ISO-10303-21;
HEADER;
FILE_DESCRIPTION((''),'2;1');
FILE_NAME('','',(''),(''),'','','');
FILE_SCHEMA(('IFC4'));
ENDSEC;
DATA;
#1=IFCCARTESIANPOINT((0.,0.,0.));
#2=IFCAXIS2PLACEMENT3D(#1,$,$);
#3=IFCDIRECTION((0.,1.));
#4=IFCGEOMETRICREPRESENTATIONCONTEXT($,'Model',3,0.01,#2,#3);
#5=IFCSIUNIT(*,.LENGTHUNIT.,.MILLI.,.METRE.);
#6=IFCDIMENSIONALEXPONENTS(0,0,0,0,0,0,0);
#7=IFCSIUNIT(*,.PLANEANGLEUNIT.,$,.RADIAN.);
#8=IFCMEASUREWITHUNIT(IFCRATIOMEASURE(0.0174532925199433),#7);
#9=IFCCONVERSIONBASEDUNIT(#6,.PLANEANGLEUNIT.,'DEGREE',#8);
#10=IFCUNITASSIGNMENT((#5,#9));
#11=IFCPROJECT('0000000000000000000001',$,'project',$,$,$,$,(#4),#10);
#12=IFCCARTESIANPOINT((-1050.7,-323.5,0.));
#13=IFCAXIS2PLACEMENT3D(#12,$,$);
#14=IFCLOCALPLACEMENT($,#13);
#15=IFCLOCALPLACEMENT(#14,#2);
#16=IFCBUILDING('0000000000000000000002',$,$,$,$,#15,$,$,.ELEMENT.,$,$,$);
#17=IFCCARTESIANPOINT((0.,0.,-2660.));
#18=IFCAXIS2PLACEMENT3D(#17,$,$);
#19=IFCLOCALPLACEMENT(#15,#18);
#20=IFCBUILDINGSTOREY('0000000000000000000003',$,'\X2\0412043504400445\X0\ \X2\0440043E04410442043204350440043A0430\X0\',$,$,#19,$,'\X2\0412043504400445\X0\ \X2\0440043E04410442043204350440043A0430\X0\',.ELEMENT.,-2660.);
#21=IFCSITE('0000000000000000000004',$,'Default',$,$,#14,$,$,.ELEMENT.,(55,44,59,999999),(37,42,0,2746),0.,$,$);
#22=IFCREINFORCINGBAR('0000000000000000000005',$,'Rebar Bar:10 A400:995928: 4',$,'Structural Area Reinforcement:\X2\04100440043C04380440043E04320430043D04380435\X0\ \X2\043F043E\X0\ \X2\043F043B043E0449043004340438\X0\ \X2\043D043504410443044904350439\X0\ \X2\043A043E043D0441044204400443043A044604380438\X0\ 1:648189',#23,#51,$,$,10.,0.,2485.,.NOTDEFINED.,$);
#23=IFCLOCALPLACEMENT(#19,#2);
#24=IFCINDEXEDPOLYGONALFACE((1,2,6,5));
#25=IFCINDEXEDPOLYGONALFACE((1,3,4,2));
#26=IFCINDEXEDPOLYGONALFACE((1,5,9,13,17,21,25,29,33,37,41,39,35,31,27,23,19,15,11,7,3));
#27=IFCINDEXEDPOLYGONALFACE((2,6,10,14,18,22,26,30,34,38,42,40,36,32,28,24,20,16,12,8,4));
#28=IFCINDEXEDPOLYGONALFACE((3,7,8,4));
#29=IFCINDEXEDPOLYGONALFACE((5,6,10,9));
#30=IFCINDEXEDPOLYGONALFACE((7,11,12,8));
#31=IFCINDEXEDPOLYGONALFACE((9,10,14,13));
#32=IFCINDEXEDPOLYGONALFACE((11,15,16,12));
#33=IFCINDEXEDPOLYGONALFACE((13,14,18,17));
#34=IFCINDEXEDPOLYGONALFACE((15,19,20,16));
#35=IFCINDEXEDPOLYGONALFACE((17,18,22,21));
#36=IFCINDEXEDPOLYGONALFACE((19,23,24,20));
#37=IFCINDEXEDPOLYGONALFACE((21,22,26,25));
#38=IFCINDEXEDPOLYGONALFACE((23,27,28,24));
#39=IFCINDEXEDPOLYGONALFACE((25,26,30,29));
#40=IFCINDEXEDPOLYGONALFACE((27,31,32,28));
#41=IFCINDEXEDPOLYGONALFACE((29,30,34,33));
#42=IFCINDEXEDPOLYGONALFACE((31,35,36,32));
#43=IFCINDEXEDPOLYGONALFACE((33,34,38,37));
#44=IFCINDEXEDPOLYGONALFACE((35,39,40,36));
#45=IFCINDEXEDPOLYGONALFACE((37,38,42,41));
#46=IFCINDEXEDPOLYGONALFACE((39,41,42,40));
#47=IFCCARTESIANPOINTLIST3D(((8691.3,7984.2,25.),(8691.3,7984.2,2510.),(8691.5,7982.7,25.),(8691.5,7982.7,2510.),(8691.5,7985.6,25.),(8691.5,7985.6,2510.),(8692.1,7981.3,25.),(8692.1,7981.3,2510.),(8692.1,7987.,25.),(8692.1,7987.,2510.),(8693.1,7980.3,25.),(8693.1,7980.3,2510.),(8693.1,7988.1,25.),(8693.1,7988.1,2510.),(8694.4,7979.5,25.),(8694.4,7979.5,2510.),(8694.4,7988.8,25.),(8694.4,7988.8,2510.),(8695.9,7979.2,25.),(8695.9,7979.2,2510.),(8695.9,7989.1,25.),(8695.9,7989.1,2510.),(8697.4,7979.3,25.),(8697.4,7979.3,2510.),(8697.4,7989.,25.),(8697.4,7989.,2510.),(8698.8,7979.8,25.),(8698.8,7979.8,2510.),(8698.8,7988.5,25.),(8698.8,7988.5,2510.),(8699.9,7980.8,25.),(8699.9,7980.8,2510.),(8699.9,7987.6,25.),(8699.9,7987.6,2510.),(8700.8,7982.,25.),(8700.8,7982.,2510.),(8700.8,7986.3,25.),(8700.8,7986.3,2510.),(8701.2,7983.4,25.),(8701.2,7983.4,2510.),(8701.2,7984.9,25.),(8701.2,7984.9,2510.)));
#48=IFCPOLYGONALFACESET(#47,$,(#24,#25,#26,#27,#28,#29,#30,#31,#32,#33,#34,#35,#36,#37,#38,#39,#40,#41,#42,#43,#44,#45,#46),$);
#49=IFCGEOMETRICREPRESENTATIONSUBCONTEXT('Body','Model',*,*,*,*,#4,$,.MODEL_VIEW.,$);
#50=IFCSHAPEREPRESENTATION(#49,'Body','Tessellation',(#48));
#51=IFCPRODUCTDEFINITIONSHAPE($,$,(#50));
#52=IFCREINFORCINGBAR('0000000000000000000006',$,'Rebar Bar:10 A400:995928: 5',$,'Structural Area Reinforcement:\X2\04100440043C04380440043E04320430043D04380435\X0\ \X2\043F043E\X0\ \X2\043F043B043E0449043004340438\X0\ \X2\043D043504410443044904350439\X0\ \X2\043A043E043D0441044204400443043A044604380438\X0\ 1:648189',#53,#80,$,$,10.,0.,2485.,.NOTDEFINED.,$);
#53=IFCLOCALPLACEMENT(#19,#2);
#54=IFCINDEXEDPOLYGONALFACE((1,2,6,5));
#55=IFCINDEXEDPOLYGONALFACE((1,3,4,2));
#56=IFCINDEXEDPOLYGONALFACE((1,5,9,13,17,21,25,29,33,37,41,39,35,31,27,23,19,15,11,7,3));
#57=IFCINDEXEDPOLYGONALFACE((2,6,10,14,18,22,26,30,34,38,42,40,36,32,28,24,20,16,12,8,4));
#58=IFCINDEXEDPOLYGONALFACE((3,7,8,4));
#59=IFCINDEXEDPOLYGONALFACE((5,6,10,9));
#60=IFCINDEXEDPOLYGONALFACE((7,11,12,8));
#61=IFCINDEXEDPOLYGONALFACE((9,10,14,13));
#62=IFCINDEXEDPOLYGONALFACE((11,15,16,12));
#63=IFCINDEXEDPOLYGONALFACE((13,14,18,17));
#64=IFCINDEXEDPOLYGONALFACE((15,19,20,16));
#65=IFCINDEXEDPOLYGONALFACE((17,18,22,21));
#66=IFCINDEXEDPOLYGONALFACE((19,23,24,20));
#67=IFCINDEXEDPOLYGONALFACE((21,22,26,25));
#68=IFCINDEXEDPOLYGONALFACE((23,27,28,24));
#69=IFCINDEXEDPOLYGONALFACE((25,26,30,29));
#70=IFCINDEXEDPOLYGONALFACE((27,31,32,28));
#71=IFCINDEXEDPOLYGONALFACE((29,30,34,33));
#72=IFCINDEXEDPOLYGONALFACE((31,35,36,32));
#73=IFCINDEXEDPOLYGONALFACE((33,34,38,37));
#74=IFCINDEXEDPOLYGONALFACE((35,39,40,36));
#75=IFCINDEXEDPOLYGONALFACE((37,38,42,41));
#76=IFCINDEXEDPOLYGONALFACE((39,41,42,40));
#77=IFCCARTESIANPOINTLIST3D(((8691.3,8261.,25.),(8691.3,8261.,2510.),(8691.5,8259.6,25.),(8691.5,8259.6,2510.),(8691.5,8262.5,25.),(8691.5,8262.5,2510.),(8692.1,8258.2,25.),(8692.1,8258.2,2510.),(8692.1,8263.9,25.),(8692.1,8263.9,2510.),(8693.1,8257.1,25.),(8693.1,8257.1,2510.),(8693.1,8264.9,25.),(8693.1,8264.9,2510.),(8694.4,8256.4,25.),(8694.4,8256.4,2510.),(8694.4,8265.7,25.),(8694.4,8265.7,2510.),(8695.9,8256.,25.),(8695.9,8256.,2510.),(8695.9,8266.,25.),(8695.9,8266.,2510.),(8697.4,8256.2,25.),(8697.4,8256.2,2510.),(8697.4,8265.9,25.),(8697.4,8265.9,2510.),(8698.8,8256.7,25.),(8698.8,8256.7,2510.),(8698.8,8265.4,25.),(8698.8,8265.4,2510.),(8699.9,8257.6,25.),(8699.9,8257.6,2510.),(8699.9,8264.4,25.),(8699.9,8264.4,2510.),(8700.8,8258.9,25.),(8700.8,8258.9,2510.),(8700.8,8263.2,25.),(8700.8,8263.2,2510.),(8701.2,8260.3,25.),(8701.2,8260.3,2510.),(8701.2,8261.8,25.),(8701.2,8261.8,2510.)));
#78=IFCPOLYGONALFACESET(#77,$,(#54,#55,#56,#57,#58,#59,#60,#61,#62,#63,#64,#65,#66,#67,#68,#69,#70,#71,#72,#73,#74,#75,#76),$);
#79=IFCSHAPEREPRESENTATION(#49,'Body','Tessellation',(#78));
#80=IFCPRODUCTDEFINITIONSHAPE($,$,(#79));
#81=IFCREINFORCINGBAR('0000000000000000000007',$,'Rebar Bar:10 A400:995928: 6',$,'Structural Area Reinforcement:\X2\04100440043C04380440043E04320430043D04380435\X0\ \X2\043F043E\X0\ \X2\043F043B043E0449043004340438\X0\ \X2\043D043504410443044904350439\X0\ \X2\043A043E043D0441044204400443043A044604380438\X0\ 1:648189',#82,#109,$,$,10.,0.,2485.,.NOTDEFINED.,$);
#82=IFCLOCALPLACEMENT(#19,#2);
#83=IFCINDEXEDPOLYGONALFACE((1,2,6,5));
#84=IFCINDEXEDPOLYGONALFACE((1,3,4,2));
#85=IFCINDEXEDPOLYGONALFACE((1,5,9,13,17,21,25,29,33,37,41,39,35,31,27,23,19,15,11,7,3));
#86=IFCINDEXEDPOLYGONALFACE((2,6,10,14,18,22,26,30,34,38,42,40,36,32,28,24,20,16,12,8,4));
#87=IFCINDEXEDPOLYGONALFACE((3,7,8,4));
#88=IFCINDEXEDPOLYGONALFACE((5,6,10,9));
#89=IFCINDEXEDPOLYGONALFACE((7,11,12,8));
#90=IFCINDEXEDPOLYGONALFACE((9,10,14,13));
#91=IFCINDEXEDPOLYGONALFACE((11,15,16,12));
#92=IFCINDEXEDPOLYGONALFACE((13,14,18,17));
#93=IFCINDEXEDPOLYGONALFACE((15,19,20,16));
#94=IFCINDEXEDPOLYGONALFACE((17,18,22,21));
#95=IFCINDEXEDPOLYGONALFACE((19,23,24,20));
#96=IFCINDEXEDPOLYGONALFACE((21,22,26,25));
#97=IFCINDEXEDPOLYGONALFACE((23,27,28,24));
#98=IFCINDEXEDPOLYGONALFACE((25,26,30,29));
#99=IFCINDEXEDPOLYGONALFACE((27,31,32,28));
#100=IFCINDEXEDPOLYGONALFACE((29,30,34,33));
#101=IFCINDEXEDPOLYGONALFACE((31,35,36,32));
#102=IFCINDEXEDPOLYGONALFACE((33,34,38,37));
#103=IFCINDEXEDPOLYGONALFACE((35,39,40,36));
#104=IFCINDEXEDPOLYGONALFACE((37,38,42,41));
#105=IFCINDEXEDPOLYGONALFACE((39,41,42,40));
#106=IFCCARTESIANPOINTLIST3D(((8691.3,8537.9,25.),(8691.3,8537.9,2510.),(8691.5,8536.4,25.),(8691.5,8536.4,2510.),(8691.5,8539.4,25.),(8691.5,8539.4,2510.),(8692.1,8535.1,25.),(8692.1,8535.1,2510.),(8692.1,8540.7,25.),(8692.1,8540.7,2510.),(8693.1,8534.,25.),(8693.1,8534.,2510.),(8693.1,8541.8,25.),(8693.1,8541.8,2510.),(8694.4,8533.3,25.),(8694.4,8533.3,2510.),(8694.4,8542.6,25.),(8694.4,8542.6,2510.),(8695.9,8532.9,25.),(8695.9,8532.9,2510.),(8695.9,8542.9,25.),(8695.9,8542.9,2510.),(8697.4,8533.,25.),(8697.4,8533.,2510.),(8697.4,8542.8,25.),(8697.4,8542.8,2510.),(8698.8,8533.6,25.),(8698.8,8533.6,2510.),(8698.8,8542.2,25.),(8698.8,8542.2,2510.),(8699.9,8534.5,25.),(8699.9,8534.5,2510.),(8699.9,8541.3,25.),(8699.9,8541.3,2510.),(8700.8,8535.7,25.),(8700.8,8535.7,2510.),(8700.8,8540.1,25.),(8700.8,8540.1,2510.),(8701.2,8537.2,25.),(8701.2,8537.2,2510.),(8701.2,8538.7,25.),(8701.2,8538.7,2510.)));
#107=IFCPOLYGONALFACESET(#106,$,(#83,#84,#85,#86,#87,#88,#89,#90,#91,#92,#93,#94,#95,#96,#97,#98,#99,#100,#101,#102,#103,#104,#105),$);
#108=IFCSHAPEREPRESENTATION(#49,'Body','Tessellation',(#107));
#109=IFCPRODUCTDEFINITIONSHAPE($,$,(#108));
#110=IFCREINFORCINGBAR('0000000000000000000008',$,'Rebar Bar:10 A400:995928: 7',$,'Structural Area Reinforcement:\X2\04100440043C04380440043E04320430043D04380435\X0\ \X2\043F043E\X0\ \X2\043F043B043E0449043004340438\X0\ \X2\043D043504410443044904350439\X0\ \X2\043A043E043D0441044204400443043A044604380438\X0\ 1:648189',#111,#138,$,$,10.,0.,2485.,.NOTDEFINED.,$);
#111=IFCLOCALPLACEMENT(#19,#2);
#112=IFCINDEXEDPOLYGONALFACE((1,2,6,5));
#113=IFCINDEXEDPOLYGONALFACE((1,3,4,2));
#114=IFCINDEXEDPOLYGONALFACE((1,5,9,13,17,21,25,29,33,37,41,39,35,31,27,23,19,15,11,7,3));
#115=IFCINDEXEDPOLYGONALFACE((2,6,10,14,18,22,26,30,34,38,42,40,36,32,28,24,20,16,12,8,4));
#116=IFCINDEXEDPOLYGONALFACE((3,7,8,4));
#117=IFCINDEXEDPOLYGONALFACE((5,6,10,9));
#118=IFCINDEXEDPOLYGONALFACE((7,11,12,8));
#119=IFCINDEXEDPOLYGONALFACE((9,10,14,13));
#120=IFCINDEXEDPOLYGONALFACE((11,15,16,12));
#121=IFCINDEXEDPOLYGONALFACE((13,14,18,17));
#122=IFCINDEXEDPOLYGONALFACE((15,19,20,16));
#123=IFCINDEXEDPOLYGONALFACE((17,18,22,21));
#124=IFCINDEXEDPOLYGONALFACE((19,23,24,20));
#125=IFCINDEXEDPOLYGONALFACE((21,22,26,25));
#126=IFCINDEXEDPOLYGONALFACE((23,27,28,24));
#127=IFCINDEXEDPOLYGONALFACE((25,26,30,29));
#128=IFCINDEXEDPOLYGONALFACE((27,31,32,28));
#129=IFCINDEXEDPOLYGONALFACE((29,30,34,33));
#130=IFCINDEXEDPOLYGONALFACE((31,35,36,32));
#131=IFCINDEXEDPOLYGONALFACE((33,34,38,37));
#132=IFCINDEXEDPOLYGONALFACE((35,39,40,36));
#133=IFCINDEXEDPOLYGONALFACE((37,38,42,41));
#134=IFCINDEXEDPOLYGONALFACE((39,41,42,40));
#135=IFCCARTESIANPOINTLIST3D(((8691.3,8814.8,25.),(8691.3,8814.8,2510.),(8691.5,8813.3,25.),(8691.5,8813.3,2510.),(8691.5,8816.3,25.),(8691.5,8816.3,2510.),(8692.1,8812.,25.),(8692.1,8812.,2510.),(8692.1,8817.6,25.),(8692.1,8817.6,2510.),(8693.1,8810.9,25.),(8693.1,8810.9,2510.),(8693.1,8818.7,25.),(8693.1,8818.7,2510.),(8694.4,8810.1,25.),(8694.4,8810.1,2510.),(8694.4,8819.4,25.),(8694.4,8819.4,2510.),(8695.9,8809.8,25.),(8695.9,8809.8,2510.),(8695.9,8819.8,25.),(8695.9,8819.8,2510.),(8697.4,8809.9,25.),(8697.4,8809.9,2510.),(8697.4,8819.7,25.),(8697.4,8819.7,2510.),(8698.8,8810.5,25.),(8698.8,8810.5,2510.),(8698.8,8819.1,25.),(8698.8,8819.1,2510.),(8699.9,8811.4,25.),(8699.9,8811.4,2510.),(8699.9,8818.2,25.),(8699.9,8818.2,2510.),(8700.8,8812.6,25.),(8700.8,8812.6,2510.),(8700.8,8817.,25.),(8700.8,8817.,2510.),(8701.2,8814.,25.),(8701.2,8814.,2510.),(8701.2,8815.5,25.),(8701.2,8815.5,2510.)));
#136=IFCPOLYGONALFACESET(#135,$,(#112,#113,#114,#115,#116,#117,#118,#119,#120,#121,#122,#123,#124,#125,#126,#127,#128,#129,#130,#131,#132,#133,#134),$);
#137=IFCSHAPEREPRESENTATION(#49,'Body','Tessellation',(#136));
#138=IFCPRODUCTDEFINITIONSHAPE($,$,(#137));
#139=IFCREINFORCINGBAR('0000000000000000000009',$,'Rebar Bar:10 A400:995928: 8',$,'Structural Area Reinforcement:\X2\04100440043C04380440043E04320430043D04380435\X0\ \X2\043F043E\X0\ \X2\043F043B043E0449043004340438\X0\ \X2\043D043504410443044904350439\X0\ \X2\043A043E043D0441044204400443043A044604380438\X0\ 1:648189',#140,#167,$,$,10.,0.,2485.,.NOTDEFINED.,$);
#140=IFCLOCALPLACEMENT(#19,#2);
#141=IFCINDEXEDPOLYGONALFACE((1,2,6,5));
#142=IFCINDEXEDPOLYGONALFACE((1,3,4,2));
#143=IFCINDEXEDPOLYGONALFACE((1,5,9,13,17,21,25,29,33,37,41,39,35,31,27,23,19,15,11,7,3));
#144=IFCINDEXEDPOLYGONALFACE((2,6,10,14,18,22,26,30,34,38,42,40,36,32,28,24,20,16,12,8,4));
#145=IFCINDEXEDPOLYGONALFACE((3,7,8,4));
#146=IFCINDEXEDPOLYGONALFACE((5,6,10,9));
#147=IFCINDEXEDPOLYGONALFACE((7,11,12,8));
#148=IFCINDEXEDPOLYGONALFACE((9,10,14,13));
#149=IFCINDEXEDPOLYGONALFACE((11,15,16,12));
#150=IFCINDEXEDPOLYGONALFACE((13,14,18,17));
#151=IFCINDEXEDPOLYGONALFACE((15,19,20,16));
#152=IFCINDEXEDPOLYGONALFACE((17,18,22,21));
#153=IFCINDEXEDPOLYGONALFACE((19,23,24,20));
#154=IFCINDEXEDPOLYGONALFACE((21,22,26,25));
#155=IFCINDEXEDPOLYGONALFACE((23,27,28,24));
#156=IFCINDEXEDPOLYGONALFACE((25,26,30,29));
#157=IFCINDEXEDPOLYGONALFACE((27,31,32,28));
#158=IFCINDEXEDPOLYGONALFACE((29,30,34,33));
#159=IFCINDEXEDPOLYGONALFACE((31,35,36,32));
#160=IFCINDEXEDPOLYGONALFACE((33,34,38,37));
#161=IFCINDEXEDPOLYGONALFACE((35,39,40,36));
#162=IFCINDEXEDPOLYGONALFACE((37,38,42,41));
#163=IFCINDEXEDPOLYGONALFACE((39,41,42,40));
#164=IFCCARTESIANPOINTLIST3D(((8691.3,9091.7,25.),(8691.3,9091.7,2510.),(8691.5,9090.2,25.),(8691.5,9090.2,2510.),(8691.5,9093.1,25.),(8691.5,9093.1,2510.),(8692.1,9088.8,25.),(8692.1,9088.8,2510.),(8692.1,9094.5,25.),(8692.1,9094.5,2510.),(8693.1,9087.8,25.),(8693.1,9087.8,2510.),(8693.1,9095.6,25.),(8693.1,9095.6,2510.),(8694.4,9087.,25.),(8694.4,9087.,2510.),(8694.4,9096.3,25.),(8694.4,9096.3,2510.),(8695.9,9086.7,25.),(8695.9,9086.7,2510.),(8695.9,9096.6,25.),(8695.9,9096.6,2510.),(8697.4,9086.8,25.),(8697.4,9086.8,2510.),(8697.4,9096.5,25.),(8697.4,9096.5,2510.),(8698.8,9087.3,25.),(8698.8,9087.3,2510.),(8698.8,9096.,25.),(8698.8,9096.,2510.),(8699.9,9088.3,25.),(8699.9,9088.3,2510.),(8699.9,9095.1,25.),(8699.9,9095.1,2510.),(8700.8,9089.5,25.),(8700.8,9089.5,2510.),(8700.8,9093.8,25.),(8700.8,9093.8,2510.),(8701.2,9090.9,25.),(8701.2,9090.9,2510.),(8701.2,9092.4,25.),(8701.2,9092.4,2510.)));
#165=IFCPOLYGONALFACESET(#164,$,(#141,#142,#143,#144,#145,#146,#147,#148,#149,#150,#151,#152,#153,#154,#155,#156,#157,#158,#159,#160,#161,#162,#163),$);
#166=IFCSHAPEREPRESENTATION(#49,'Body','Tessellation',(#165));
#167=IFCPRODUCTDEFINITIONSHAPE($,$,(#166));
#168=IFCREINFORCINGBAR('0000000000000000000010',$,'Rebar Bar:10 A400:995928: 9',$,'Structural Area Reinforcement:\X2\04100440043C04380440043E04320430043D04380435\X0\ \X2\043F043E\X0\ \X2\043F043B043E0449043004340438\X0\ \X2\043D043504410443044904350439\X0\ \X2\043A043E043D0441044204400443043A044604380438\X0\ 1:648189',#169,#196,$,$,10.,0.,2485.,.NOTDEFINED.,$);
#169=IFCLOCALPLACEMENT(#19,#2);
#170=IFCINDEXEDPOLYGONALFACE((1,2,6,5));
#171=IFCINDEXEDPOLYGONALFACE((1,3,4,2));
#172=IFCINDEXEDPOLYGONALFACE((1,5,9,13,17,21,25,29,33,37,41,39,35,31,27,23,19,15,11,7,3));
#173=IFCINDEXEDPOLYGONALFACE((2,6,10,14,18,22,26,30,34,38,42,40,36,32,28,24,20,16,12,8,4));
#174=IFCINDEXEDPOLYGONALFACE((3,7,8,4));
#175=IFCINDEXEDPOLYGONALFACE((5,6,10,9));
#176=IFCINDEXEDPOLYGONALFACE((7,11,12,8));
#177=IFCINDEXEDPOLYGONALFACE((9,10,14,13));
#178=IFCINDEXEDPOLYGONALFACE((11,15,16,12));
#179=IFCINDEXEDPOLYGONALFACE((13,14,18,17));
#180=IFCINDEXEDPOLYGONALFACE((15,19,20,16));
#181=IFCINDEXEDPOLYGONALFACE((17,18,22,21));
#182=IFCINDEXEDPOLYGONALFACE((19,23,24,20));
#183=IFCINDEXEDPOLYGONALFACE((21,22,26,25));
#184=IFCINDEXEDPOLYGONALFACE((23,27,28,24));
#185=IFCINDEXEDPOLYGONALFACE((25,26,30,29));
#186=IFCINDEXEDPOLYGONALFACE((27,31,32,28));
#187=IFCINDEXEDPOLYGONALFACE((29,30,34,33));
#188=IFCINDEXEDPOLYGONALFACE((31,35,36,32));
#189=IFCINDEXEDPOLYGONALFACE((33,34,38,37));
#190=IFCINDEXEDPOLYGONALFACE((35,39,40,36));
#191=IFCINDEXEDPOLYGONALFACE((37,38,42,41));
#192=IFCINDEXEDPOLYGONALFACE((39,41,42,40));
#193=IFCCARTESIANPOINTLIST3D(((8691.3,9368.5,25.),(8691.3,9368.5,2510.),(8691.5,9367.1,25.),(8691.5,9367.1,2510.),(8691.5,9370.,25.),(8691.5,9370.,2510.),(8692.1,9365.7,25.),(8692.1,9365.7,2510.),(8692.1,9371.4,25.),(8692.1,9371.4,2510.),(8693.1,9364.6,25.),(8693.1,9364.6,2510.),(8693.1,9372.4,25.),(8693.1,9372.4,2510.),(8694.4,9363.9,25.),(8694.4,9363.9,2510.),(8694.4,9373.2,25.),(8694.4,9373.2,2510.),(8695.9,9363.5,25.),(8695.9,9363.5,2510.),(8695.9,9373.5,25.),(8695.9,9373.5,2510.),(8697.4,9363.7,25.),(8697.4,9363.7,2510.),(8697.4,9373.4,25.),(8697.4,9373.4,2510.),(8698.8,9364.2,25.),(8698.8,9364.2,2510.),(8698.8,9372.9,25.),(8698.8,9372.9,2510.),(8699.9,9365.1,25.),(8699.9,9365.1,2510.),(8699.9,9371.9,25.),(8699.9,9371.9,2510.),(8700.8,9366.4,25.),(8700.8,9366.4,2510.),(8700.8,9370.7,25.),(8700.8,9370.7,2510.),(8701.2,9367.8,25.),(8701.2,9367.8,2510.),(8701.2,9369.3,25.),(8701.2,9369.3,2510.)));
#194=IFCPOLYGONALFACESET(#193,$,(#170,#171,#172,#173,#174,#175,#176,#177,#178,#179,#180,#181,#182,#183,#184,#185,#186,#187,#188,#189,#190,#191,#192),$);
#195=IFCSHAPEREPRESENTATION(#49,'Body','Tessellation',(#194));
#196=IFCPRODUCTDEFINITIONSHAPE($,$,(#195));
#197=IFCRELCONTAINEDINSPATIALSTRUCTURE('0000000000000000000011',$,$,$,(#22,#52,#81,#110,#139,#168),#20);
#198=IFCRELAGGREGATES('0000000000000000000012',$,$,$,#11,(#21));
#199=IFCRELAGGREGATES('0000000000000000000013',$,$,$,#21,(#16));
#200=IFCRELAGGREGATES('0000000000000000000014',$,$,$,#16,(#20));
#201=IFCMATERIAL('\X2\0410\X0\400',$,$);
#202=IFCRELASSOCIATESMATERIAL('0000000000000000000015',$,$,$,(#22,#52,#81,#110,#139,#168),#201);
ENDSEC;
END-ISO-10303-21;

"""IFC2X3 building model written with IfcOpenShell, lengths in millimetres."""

from ifc_helpers import new_model, entity, si_unit, converted_unit, direction, frame, origin, place, context, subcontext, project, spatial, material, element, save


model = new_model("IFC2X3")

# Units and contexts
model_context = context("Model", 3, precision=0.01, world=origin(), true_north=direction((0.0, 1.0)))
body_context = subcontext(model_context, "Body", "Model", "MODEL_VIEW")
ifc_project = project(units=[si_unit("LENGTHUNIT", "METRE", prefix="MILLI"), converted_unit("PLANEANGLEUNIT", "DEGREE", entity("IfcRatioMeasure", 0.0174532925199433), si_unit("PLANEANGLEUNIT", "RADIAN"), dimensions=[0, 0, 0, 0, 0, 0, 0])], contexts=[model_context])

# Site, building, storey
site_placement = place(None, frame((-1050.7, -323.5, 0.0)))
site = spatial("IfcSite", under=ifc_project, at=site_placement, Name="Default", CompositionType="ELEMENT", RefLatitude=(55, 44, 59, 999999), RefLongitude=(37, 42, 0, 2746), RefElevation=0.0)
building_placement = place(site_placement, origin())
building = spatial("IfcBuilding", under=site, at=building_placement, CompositionType="ELEMENT")
storey_placement = place(building_placement, frame((0.0, 0.0, -2660.0)))
storey = spatial("IfcBuildingStorey", under=building, at=storey_placement, Name="Верх ростверка", LongName="Верх ростверка", CompositionType="ELEMENT", Elevation=-2660.0)

# Reinforcing bars
ifc_material = material(Name="А400")
reinforcing_bar_1_placement = place(storey_placement, origin())
element("IfcReinforcingBar", 1, at=reinforcing_bar_1_placement, inside=storey, material=ifc_material, Name="Rebar Bar:10 A400:995928: 4", ObjectType="Structural Area Reinforcement:Армирование по площади несущей конструкции 1:648189", BarLength=2485.0, BarRole="NOTDEFINED", CrossSectionArea=0.0, NominalDiameter=10.0, context=body_context, shape_type="AdvancedSweptSolid", body=[
    entity("IfcSweptDiskSolid", entity("IfcCompositeCurve", [entity("IfcCompositeCurveSegment", "CONTINUOUS", True, entity("IfcPolyline", [entity("IfcCartesianPoint", [8696.3, 7984.2, 2510.0]), entity("IfcCartesianPoint", [8696.3, 7984.2, 25.0])]))], False), 5.0, None, 0.0, 1.0),
])
reinforcing_bar_2_placement = place(storey_placement, origin())
element("IfcReinforcingBar", 2, at=reinforcing_bar_2_placement, inside=storey, material=ifc_material, Name="Rebar Bar:10 A400:995928: 5", ObjectType="Structural Area Reinforcement:Армирование по площади несущей конструкции 1:648189", BarLength=2485.0, BarRole="NOTDEFINED", CrossSectionArea=0.0, NominalDiameter=10.0, context=body_context, shape_type="AdvancedSweptSolid", body=[
    entity("IfcSweptDiskSolid", entity("IfcCompositeCurve", [entity("IfcCompositeCurveSegment", "CONTINUOUS", True, entity("IfcPolyline", [entity("IfcCartesianPoint", [8696.3, 8261.0, 2510.0]), entity("IfcCartesianPoint", [8696.3, 8261.0, 25.0])]))], False), 5.0, None, 0.0, 1.0),
])
reinforcing_bar_3_placement = place(storey_placement, origin())
element("IfcReinforcingBar", 3, at=reinforcing_bar_3_placement, inside=storey, material=ifc_material, Name="Rebar Bar:10 A400:995928: 6", ObjectType="Structural Area Reinforcement:Армирование по площади несущей конструкции 1:648189", BarLength=2485.0, BarRole="NOTDEFINED", CrossSectionArea=0.0, NominalDiameter=10.0, context=body_context, shape_type="AdvancedSweptSolid", body=[
    entity("IfcSweptDiskSolid", entity("IfcCompositeCurve", [entity("IfcCompositeCurveSegment", "CONTINUOUS", True, entity("IfcPolyline", [entity("IfcCartesianPoint", [8696.3, 8537.9, 2510.0]), entity("IfcCartesianPoint", [8696.3, 8537.9, 25.0])]))], False), 5.0, None, 0.0, 1.0),
])
reinforcing_bar_4_placement = place(storey_placement, origin())
element("IfcReinforcingBar", 4, at=reinforcing_bar_4_placement, inside=storey, material=ifc_material, Name="Rebar Bar:10 A400:995928: 7", ObjectType="Structural Area Reinforcement:Армирование по площади несущей конструкции 1:648189", BarLength=2485.0, BarRole="NOTDEFINED", CrossSectionArea=0.0, NominalDiameter=10.0, context=body_context, shape_type="AdvancedSweptSolid", body=[
    entity("IfcSweptDiskSolid", entity("IfcCompositeCurve", [entity("IfcCompositeCurveSegment", "CONTINUOUS", True, entity("IfcPolyline", [entity("IfcCartesianPoint", [8696.3, 8814.8, 2510.0]), entity("IfcCartesianPoint", [8696.3, 8814.8, 25.0])]))], False), 5.0, None, 0.0, 1.0),
])
reinforcing_bar_5_placement = place(storey_placement, origin())
element("IfcReinforcingBar", 5, at=reinforcing_bar_5_placement, inside=storey, material=ifc_material, Name="Rebar Bar:10 A400:995928: 8", ObjectType="Structural Area Reinforcement:Армирование по площади несущей конструкции 1:648189", BarLength=2485.0, BarRole="NOTDEFINED", CrossSectionArea=0.0, NominalDiameter=10.0, context=body_context, shape_type="AdvancedSweptSolid", body=[
    entity("IfcSweptDiskSolid", entity("IfcCompositeCurve", [entity("IfcCompositeCurveSegment", "CONTINUOUS", True, entity("IfcPolyline", [entity("IfcCartesianPoint", [8696.3, 9091.7, 2510.0]), entity("IfcCartesianPoint", [8696.3, 9091.7, 25.0])]))], False), 5.0, None, 0.0, 1.0),
])
reinforcing_bar_6_placement = place(storey_placement, origin())
element("IfcReinforcingBar", 6, at=reinforcing_bar_6_placement, inside=storey, material=ifc_material, Name="Rebar Bar:10 A400:995928: 9", ObjectType="Structural Area Reinforcement:Армирование по площади несущей конструкции 1:648189", BarLength=2485.0, BarRole="NOTDEFINED", CrossSectionArea=0.0, NominalDiameter=10.0, context=body_context, shape_type="AdvancedSweptSolid", body=[
    entity("IfcSweptDiskSolid", entity("IfcCompositeCurve", [entity("IfcCompositeCurveSegment", "CONTINUOUS", True, entity("IfcPolyline", [entity("IfcCartesianPoint", [8696.3, 9368.5, 2510.0]), entity("IfcCartesianPoint", [8696.3, 9368.5, 25.0])]))], False), 5.0, None, 0.0, 1.0),
])

save(model, "model.ifc")
